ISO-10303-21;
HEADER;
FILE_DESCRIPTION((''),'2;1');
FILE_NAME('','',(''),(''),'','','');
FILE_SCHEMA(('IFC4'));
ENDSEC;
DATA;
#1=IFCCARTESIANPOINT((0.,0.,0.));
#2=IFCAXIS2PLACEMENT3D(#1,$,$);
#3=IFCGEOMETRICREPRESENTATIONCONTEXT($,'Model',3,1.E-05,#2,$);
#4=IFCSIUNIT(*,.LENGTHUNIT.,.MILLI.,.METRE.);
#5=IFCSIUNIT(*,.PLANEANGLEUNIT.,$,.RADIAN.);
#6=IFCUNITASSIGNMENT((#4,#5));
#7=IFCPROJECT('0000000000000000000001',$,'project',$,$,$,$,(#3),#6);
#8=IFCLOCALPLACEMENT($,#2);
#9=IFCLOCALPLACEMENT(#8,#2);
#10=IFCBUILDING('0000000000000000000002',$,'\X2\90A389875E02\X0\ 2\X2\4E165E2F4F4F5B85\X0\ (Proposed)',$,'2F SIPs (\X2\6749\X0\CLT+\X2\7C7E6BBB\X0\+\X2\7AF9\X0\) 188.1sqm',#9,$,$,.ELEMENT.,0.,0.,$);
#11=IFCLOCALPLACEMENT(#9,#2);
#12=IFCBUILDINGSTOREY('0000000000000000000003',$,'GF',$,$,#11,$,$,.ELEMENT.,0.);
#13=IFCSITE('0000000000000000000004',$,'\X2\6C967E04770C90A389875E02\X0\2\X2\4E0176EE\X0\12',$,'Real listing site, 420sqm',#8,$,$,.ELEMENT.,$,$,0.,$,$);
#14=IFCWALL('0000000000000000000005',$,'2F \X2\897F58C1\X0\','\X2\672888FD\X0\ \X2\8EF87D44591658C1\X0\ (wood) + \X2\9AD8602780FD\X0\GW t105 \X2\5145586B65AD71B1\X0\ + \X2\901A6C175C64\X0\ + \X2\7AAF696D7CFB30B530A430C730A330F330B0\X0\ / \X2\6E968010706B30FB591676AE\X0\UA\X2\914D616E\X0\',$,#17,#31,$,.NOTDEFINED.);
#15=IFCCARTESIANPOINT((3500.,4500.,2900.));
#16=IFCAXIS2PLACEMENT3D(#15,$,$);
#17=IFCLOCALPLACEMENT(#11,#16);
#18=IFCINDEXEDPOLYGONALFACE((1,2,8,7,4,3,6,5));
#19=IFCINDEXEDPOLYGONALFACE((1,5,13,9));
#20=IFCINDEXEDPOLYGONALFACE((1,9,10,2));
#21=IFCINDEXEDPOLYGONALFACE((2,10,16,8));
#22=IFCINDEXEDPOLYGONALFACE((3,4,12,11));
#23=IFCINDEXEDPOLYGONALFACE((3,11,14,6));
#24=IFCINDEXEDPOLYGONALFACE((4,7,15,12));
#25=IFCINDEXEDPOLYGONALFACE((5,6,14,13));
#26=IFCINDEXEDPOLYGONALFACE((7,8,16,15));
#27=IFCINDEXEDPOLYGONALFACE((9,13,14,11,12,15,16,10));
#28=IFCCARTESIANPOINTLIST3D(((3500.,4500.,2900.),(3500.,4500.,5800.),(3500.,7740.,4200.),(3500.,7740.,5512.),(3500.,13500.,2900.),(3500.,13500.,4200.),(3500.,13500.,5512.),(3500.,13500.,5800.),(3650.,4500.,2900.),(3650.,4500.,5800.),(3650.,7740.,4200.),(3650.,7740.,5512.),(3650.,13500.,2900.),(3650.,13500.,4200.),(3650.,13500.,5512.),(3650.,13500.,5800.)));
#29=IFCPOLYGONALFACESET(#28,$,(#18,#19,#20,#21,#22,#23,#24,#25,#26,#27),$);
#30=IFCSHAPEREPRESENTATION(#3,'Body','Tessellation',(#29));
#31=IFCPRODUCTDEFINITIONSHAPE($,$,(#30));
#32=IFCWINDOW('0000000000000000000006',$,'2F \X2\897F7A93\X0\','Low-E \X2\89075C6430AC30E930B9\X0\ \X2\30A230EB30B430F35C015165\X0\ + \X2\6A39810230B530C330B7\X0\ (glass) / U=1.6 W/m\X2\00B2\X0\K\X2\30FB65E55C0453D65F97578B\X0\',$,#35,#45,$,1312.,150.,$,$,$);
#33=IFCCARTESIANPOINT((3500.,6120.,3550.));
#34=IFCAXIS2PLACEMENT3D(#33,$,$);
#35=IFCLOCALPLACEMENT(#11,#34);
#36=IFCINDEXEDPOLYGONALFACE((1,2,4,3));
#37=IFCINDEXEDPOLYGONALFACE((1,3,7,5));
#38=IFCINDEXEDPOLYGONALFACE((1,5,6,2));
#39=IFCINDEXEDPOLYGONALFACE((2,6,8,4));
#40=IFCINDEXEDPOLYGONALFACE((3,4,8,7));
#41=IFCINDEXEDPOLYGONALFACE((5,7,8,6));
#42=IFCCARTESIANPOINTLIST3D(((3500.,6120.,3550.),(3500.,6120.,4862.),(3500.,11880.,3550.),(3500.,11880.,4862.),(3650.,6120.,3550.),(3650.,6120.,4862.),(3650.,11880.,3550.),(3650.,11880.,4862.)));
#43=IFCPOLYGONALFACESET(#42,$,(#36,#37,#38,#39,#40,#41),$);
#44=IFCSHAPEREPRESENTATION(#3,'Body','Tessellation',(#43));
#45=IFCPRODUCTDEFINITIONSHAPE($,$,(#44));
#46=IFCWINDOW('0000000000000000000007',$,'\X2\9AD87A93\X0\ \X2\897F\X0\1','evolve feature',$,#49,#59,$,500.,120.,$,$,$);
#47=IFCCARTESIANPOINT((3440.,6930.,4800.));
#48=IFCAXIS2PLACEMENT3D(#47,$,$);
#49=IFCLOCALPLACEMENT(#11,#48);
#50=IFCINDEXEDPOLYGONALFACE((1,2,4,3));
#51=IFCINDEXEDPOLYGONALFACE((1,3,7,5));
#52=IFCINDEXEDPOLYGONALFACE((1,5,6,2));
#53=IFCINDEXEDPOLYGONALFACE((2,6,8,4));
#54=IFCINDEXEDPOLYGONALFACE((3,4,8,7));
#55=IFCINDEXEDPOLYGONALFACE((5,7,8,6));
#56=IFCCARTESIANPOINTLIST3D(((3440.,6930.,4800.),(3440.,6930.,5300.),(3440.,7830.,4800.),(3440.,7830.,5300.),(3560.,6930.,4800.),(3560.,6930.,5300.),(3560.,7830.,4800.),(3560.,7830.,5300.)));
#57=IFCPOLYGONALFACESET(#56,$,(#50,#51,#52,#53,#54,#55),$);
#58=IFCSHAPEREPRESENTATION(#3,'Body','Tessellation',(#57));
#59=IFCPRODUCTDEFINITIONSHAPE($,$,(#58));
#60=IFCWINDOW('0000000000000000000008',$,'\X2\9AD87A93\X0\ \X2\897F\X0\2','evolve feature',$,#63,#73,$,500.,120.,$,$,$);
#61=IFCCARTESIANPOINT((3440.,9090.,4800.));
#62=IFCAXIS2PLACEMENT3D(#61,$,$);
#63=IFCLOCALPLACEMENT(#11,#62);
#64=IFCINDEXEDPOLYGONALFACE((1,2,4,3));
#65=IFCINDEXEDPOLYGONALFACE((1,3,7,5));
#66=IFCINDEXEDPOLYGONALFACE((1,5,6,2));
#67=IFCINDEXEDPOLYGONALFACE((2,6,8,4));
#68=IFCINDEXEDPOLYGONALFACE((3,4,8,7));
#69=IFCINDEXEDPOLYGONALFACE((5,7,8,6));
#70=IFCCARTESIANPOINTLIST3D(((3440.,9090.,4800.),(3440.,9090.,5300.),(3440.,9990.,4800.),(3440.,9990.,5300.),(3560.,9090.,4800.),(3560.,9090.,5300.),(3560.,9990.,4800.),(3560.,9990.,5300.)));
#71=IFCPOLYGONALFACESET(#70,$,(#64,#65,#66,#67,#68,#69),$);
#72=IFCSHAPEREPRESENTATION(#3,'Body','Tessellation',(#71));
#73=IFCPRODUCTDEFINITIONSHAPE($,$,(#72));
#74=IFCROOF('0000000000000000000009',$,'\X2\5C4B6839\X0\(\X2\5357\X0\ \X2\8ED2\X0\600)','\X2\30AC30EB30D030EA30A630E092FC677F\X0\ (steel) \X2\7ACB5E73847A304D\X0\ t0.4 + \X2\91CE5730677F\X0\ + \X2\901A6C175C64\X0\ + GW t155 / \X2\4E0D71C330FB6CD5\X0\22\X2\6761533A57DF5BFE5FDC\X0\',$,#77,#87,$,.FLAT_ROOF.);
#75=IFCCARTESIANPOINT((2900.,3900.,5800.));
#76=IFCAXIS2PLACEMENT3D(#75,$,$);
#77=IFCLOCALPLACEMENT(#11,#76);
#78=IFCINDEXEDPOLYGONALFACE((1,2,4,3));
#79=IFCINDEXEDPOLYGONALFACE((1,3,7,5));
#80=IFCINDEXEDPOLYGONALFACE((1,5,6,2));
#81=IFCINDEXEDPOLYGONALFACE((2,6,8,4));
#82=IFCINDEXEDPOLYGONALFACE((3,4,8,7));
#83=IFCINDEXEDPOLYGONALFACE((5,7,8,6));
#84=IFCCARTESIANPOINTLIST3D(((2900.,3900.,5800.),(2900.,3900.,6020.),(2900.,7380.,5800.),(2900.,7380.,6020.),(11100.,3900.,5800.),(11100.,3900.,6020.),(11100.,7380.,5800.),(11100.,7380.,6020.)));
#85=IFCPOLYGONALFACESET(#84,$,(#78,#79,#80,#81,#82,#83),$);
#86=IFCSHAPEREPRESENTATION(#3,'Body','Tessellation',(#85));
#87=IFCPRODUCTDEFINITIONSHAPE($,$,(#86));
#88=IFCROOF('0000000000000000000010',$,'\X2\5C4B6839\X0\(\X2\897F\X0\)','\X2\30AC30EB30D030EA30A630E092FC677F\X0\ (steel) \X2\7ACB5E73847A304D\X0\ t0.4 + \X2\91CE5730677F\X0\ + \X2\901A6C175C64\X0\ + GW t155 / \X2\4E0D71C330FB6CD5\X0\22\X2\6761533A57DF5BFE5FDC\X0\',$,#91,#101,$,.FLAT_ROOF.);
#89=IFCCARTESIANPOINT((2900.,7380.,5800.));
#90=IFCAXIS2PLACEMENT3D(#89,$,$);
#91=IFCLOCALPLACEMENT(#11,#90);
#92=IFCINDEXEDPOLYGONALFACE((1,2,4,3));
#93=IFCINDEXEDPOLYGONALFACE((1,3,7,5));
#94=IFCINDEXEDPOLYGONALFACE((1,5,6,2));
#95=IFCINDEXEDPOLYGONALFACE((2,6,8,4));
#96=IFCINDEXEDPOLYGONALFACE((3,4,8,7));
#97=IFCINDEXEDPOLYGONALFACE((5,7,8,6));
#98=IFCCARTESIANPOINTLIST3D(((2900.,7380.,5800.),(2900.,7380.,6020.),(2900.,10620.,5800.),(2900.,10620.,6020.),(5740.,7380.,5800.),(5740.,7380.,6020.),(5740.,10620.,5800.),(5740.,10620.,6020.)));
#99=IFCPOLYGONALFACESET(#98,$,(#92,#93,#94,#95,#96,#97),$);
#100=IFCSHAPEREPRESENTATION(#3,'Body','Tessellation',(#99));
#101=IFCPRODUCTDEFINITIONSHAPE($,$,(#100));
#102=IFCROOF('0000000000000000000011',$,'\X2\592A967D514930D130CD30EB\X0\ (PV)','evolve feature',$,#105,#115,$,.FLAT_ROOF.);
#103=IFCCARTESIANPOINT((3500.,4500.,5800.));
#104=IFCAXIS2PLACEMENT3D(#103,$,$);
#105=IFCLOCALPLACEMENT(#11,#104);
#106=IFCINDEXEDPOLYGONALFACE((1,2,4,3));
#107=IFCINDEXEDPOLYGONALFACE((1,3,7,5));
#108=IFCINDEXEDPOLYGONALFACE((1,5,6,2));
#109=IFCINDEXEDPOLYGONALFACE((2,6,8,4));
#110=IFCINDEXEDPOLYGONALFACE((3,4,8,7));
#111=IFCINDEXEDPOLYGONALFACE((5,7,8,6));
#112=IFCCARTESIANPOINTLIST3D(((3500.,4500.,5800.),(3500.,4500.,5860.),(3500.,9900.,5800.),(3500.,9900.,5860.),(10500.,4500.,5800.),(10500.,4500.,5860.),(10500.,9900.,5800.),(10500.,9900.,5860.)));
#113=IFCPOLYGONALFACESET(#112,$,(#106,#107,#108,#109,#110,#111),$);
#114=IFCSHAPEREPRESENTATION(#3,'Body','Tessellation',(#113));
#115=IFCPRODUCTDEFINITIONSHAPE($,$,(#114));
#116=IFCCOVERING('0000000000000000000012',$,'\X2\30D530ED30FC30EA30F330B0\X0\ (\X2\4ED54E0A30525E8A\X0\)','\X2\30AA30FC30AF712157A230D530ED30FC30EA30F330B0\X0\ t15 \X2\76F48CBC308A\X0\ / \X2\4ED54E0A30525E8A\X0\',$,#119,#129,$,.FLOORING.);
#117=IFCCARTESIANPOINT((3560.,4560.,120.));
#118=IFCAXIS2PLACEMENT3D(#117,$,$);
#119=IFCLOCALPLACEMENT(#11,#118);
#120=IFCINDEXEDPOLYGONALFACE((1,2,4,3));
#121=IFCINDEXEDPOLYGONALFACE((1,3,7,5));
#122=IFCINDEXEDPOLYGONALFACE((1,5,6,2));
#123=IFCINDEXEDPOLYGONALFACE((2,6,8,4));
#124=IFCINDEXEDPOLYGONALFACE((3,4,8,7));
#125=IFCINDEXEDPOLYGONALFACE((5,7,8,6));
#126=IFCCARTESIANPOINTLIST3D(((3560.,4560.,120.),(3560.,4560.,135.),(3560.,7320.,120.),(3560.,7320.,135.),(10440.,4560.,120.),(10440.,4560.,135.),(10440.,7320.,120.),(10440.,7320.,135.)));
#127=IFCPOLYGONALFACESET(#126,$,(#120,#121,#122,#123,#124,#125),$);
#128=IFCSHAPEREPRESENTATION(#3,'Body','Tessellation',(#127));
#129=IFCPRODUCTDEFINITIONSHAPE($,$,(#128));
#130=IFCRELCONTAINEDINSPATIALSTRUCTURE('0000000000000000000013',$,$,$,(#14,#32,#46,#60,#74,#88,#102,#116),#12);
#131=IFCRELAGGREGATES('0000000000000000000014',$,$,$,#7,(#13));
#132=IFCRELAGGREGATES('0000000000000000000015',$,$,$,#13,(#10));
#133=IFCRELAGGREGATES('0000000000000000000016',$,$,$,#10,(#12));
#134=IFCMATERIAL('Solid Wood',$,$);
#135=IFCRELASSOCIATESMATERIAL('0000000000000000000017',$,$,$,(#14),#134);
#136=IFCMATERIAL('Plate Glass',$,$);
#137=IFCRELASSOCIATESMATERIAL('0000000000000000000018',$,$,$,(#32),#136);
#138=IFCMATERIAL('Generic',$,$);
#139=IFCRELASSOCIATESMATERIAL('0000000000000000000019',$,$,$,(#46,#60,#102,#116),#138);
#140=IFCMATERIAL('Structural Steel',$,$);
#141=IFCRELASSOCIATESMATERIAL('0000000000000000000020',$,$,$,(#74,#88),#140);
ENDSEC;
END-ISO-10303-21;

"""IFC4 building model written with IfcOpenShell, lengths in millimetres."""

from ifc_helpers import new_model, si_unit, frame, frame_2d, origin, place, context, project, spatial, rectangle, extrude, material, element, fill, save


model = new_model("IFC4")

# Units and contexts
model_context = context("Model", 3, precision=1e-05, world=origin())
ifc_project = project(units=[si_unit("LENGTHUNIT", "METRE", prefix="MILLI"), si_unit("PLANEANGLEUNIT", "RADIAN")], contexts=[model_context])

# Site, building, storey
site_placement = place(None, origin())
site = spatial("IfcSite", under=ifc_project, at=site_placement, Name="沖縄県那覇市2丁目12", ObjectType="Real listing site, 420sqm", CompositionType="ELEMENT", RefElevation=0.0)
building_placement = place(site_placement, origin())
building = spatial("IfcBuilding", under=site, at=building_placement, Name="那覇市 2世帯住宅 (Proposed)", ObjectType="2F SIPs (杉CLT+籾殻+竹) 188.1sqm", CompositionType="ELEMENT", ElevationOfRefHeight=0.0, ElevationOfTerrain=0.0)
storey_placement = place(building_placement, origin())
storey = spatial("IfcBuildingStorey", under=building, at=storey_placement, Name="GF", CompositionType="ELEMENT", Elevation=0.0)

# Shared definitions
ifc_material_1 = material(Name="Solid Wood")
ifc_material_2 = material(Name="Generic")

# Shared definitions
ifc_material_3 = material(Name="Plate Glass")

# Wall, openings, windows
wall_1_placement = place(storey_placement, frame((3500.0, 4500.0, 2900.0)))
wall_1 = element("IfcWall", 1, at=wall_1_placement, inside=storey, material=ifc_material_1, Name="2F 西壁", Description="木製 軸組外壁 (wood) + 高性能GW t105 充填断熱 + 通気層 + 窯業系サイディング / 準耐火・外皮UA配慮", PredefinedType="NOTDEFINED", context=model_context, shape_type="SweptSolid", body=[
    extrude(rectangle(XDim=150.0, YDim=9000.0, at=frame_2d((75.0, 4500.0))), frame((3500.0, 4500.0, 2900.0)), (0.0, 0.0, 1.0), 2900.0),
])
opening_1_placement = place(storey_placement, frame((3500.0, 6120.0, 3550.0)))
opening_1 = element("IfcOpeningElement", 2, at=opening_1_placement, cuts=wall_1, PredefinedType="NOTDEFINED", context=model_context, shape_type="SweptSolid", body=[
    extrude(rectangle(XDim=150.0, YDim=5760.0, at=frame_2d((75.0, 2880.0))), frame((3500.0, 6120.0, 3550.0)), (0.0, 0.0, 1.0), 1312.0),
])
opening_2_placement = place(storey_placement, frame((3440.0, 6930.0, 4800.0)))
opening_2 = element("IfcOpeningElement", 3, at=opening_2_placement, cuts=wall_1, PredefinedType="NOTDEFINED", context=model_context, shape_type="SweptSolid", body=[
    extrude(rectangle(XDim=120.0, YDim=900.0, at=frame_2d((60.0, 450.0))), frame((3440.0, 6930.0, 4800.0)), (0.0, 0.0, 1.0), 500.0),
])
opening_3_placement = place(storey_placement, frame((3440.0, 9090.0, 4800.0)))
opening_3 = element("IfcOpeningElement", 4, at=opening_3_placement, cuts=wall_1, PredefinedType="NOTDEFINED", context=model_context, shape_type="SweptSolid", body=[
    extrude(rectangle(XDim=120.0, YDim=900.0, at=frame_2d((60.0, 450.0))), frame((3440.0, 9090.0, 4800.0)), (0.0, 0.0, 1.0), 500.0),
])
window_1_placement = place(storey_placement, frame((3500.0, 6120.0, 3550.0)))
window_1 = element("IfcWindow", 5, at=window_1_placement, inside=storey, material=ifc_material_3, Name="2F 西窓", Description="Low-E 複層ガラス アルゴン封入 + 樹脂サッシ (glass) / U=1.6 W/m²K・日射取得型", OverallHeight=1312.0, OverallWidth=150.0, context=model_context, shape_type="SweptSolid", body=[
    extrude(rectangle(XDim=150.0, YDim=5760.0, at=frame_2d((75.0, 2880.0))), frame((3500.0, 6120.0, 3550.0)), (0.0, 0.0, 1.0), 1312.0),
])
fill(opening_1, window_1)
window_2_placement = place(storey_placement, frame((3440.0, 6930.0, 4800.0)))
window_2 = element("IfcWindow", 6, at=window_2_placement, inside=storey, material=ifc_material_2, Name="高窓 西1", Description="evolve feature", OverallHeight=500.0, OverallWidth=120.0, context=model_context, shape_type="SweptSolid", body=[
    extrude(rectangle(XDim=120.0, YDim=900.0, at=frame_2d((60.0, 450.0))), frame((3440.0, 6930.0, 4800.0)), (0.0, 0.0, 1.0), 500.0),
])
fill(opening_2, window_2)
window_3_placement = place(storey_placement, frame((3440.0, 9090.0, 4800.0)))
window_3 = element("IfcWindow", 7, at=window_3_placement, inside=storey, material=ifc_material_2, Name="高窓 西2", Description="evolve feature", OverallHeight=500.0, OverallWidth=120.0, context=model_context, shape_type="SweptSolid", body=[
    extrude(rectangle(XDim=120.0, YDim=900.0, at=frame_2d((60.0, 450.0))), frame((3440.0, 9090.0, 4800.0)), (0.0, 0.0, 1.0), 500.0),
])
fill(opening_3, window_3)

# Roofs
ifc_material_4 = material(Name="Structural Steel")
roof_1_placement = place(storey_placement, frame((2900.0, 3900.0, 5800.0)))
element("IfcRoof", 8, at=roof_1_placement, inside=storey, material=ifc_material_4, Name="屋根(南 軒600)", Description="ガルバリウム鋼板 (steel) 立平葺き t0.4 + 野地板 + 通気層 + GW t155 / 不燃・法22条区域対応", PredefinedType="FLAT_ROOF", context=model_context, shape_type="SweptSolid", body=[
    extrude(rectangle(XDim=8200.0, YDim=3480.0, at=frame_2d((4100.0, 1740.0))), frame((2900.0, 3900.0, 5800.0)), (0.0, 0.0, 1.0), 220.0),
])
roof_2_placement = place(storey_placement, frame((2900.0, 7380.0, 5800.0)))
element("IfcRoof", 9, at=roof_2_placement, inside=storey, material=ifc_material_4, Name="屋根(西)", Description="ガルバリウム鋼板 (steel) 立平葺き t0.4 + 野地板 + 通気層 + GW t155 / 不燃・法22条区域対応", PredefinedType="FLAT_ROOF", context=model_context, shape_type="SweptSolid", body=[
    extrude(rectangle(XDim=2840.0, YDim=3240.0, at=frame_2d((1420.0, 1620.0))), frame((2900.0, 7380.0, 5800.0)), (0.0, 0.0, 1.0), 220.0),
])
roof_3_placement = place(storey_placement, frame((3500.0, 4500.0, 5800.0)))
element("IfcRoof", 10, at=roof_3_placement, inside=storey, material=ifc_material_2, Name="太陽光パネル (PV)", Description="evolve feature", PredefinedType="FLAT_ROOF", context=model_context, shape_type="SweptSolid", body=[
    extrude(rectangle(XDim=7000.0, YDim=5400.0, at=frame_2d((3500.0, 2700.0))), frame((3500.0, 4500.0, 5800.0)), (0.0, 0.0, 1.0), 60.0),
])

# Covering
covering_placement = place(storey_placement, frame((3560.0, 4560.0, 120.0)))
element("IfcCovering", 11, at=covering_placement, inside=storey, material=ifc_material_2, Name="フローリング (仕上げ床)", Description="オーク無垢フローリング t15 直貼り / 仕上げ床", PredefinedType="FLOORING", context=model_context, shape_type="SweptSolid", body=[
    extrude(rectangle(XDim=6880.0, YDim=2760.0, at=frame_2d((3440.0, 1380.0))), frame((3560.0, 4560.0, 120.0)), (0.0, 0.0, 1.0), 15.0),
])

save(model, "model.ifc")
